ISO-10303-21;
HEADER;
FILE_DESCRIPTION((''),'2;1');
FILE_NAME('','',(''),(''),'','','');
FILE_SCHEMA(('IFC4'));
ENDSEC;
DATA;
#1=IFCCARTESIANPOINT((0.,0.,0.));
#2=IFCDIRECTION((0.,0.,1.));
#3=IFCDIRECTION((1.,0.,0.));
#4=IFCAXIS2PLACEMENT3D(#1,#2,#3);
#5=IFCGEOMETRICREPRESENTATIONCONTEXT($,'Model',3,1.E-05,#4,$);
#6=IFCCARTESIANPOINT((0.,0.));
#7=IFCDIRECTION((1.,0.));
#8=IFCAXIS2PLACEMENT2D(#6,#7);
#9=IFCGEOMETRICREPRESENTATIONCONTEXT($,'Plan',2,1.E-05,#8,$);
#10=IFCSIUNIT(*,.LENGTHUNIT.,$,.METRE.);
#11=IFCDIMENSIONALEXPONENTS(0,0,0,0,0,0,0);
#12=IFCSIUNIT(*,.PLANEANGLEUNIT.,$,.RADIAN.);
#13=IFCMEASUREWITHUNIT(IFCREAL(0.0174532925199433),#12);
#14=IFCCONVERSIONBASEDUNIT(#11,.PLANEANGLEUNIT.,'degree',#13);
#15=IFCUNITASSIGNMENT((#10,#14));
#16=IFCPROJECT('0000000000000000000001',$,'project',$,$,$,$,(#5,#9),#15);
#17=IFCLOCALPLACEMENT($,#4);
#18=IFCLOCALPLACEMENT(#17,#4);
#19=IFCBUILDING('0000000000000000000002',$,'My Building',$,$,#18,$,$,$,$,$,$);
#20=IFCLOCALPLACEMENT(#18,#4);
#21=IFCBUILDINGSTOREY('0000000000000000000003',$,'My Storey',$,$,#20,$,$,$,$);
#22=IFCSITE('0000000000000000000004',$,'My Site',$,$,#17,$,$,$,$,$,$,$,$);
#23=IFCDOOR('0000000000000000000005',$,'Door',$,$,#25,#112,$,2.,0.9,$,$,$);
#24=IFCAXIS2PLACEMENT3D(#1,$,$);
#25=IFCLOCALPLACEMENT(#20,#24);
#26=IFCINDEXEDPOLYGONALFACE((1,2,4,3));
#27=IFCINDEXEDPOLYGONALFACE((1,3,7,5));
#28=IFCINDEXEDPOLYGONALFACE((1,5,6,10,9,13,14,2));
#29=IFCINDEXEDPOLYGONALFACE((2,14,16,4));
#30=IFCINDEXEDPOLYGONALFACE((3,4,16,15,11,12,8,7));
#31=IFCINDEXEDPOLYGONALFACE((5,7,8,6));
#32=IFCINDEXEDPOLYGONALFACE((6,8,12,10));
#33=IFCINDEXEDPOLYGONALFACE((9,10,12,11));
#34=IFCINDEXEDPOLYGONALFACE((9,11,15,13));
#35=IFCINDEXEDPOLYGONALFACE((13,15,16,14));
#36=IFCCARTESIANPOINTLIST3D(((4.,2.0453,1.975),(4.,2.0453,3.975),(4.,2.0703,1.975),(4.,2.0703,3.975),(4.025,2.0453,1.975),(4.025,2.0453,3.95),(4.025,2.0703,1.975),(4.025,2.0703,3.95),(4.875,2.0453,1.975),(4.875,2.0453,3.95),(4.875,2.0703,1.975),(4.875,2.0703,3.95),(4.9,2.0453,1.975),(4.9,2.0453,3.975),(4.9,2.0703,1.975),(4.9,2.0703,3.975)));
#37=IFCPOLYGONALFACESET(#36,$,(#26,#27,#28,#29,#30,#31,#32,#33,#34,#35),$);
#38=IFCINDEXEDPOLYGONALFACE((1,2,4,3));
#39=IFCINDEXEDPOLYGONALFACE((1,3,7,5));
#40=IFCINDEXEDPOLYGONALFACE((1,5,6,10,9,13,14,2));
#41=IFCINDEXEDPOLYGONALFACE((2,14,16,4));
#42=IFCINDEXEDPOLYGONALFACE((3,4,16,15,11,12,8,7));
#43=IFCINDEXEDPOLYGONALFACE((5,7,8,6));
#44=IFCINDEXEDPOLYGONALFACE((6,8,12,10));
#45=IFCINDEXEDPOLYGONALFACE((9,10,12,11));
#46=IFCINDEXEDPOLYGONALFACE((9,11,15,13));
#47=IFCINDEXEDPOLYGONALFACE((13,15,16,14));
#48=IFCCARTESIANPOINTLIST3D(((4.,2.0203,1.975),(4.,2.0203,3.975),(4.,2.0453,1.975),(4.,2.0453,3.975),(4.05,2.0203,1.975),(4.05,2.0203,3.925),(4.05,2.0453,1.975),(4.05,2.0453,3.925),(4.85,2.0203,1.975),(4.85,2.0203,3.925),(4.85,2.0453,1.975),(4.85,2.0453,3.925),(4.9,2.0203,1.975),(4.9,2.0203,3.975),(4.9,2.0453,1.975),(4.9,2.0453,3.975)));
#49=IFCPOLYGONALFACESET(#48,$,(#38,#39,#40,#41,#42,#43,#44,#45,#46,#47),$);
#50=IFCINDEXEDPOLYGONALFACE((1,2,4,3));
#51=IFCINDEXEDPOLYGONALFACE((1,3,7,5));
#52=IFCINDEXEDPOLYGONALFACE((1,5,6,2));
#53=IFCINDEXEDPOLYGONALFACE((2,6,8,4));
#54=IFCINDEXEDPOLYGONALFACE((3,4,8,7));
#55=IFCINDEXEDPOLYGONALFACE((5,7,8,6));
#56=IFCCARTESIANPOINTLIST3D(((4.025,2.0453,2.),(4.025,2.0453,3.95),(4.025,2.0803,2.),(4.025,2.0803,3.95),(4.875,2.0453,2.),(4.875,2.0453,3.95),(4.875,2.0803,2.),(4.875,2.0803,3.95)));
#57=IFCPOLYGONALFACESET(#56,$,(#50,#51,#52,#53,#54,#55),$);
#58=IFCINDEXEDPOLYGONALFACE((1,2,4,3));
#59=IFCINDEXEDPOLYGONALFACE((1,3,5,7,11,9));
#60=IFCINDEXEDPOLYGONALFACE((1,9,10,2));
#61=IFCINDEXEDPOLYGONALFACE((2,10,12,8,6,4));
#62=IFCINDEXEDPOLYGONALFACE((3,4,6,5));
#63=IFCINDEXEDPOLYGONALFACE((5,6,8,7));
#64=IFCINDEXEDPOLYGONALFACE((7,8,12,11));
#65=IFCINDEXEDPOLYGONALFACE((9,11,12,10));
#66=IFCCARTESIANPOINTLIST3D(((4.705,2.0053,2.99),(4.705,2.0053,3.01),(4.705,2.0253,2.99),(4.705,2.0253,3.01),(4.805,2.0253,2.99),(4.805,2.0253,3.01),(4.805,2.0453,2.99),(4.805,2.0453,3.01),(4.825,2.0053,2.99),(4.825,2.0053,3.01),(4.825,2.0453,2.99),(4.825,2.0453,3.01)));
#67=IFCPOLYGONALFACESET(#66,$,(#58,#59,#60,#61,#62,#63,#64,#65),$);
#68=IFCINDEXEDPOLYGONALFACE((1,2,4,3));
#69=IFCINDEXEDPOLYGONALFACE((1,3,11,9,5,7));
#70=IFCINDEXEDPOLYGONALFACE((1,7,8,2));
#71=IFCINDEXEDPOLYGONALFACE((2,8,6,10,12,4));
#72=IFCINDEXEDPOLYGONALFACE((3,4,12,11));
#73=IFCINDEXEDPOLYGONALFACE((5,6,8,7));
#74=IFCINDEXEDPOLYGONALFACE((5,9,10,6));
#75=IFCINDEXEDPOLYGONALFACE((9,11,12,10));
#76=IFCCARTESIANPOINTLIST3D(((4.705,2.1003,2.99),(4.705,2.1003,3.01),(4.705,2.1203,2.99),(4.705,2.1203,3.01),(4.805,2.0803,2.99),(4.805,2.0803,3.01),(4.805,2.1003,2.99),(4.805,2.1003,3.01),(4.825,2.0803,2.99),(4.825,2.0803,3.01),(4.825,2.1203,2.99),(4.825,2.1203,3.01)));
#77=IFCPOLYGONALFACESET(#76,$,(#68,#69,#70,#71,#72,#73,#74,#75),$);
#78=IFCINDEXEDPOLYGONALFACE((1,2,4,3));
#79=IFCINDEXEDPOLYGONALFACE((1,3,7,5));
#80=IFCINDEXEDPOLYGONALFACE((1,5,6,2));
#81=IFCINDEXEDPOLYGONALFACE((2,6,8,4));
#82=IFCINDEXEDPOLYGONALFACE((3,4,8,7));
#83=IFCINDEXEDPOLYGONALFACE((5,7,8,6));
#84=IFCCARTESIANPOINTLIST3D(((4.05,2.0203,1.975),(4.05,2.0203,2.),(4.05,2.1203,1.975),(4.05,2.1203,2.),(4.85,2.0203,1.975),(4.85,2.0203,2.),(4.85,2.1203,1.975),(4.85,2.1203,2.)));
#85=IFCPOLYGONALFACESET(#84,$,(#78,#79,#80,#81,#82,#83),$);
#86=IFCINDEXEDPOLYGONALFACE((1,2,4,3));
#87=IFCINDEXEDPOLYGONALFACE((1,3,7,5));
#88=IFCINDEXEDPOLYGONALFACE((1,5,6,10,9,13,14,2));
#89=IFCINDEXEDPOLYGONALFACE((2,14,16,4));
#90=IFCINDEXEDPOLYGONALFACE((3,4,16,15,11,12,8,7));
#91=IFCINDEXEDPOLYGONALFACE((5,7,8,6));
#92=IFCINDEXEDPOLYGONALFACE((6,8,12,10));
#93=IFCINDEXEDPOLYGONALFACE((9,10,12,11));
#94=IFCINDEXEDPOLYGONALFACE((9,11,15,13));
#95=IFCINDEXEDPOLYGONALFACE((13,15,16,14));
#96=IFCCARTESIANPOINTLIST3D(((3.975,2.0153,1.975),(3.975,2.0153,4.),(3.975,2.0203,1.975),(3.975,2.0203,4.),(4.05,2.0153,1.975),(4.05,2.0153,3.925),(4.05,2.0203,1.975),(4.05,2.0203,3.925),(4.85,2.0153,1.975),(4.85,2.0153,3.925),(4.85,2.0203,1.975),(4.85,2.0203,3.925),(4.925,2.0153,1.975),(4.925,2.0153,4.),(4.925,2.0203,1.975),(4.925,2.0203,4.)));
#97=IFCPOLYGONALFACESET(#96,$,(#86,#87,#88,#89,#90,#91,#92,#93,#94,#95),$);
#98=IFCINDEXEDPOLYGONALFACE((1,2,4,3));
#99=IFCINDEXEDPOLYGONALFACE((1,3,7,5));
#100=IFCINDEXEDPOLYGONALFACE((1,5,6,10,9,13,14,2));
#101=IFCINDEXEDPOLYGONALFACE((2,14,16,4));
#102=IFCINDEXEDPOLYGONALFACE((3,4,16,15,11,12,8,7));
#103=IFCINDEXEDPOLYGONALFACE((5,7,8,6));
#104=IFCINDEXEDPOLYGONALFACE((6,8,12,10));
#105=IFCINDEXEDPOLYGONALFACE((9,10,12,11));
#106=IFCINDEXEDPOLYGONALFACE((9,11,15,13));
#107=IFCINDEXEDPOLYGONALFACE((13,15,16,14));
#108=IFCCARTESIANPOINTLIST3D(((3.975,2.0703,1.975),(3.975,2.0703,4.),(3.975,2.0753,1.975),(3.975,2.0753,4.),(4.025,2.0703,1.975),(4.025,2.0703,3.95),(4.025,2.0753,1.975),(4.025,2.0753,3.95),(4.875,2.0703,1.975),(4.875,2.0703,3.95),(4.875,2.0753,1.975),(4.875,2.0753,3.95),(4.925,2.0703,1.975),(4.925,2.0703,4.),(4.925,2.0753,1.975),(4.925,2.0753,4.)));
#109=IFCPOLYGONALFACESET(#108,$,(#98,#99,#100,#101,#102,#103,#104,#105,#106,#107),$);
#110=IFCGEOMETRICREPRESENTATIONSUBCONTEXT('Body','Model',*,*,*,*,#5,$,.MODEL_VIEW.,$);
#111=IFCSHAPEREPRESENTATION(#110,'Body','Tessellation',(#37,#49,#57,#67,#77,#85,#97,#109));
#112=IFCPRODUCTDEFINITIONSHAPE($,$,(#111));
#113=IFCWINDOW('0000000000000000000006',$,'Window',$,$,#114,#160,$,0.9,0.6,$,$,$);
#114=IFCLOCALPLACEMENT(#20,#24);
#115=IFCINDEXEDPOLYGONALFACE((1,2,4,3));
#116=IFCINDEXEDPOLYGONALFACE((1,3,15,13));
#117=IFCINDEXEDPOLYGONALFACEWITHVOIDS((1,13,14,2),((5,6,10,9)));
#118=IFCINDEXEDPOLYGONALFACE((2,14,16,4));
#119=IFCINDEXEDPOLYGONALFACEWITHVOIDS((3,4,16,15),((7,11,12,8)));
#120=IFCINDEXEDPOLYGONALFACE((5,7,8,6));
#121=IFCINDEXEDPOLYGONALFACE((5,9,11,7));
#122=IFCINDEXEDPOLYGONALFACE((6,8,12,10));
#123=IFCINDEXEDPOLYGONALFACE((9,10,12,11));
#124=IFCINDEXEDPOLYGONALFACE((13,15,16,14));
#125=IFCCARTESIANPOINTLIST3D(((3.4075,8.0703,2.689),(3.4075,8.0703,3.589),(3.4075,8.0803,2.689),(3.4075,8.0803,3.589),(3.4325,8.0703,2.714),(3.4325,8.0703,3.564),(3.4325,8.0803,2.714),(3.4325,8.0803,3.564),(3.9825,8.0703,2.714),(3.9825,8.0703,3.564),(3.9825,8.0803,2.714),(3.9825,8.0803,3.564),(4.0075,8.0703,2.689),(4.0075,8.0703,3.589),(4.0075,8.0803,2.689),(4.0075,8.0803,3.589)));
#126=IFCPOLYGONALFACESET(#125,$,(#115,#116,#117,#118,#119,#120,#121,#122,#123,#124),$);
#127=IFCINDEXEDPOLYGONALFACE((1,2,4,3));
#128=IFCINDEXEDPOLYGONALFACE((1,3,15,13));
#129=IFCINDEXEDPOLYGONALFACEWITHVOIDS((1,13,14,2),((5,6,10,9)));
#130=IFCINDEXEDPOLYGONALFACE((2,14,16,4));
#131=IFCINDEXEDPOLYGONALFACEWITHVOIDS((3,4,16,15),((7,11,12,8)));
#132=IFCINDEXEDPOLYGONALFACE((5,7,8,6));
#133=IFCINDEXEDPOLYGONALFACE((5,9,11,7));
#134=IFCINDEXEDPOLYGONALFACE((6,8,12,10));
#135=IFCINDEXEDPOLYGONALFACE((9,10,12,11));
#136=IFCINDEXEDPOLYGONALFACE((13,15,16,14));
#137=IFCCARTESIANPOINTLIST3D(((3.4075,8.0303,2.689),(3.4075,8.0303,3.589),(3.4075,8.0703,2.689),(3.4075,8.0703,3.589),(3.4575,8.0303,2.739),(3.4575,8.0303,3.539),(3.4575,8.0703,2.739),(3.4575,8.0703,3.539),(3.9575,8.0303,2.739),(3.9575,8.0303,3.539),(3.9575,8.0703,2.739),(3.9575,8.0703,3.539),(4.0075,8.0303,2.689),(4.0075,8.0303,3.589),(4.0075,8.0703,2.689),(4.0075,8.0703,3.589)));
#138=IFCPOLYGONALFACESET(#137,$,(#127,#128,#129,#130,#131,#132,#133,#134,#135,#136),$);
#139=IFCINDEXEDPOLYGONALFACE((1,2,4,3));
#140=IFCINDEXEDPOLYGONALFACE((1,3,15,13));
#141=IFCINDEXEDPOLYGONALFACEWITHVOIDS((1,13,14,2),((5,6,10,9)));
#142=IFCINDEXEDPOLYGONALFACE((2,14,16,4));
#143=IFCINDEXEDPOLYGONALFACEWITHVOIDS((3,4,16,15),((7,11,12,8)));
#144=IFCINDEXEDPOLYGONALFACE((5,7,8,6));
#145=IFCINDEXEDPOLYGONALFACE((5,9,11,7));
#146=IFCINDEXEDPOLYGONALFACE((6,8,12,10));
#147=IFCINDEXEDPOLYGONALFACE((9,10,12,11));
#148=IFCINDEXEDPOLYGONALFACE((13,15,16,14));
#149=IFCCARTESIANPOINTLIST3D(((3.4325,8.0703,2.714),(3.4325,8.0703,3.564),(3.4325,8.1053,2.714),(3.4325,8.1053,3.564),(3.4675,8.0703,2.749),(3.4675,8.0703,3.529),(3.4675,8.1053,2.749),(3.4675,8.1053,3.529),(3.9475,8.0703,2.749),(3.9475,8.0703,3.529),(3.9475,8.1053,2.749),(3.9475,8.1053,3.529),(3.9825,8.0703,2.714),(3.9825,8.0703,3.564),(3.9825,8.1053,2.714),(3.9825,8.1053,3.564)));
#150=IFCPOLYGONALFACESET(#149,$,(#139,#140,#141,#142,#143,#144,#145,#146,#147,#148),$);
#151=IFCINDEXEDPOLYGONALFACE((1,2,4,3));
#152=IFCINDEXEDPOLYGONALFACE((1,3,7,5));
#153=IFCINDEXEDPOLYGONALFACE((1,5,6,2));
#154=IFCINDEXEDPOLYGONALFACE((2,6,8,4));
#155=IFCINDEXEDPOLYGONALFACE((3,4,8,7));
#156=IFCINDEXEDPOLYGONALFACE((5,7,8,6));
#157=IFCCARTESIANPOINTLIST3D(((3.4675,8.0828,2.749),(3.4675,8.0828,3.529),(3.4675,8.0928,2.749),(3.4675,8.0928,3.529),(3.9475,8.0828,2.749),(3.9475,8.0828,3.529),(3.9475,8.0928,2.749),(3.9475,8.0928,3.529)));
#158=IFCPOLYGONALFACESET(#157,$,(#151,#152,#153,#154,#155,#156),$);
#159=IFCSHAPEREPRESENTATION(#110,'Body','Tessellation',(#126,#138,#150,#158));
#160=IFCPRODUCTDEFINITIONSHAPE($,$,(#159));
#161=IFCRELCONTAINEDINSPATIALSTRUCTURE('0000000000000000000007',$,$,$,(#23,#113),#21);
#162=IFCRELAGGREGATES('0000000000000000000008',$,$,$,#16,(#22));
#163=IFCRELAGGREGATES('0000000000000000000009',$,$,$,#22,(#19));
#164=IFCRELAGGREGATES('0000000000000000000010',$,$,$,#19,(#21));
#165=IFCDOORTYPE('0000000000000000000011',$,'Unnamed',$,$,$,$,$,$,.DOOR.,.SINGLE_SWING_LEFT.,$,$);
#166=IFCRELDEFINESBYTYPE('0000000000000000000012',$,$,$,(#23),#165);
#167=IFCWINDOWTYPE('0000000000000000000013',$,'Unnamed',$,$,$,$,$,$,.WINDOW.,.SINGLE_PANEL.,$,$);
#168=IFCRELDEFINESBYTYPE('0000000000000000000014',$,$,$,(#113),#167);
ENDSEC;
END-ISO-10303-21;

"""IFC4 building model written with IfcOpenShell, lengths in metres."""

from ifc_helpers import new_model, entity, si_unit, converted_unit, frame, origin_with_axes, origin_2d_with_axis, place, context, subcontext, project, spatial, line, indexed_curve, outline, extrude, shape, source, transform, mapped, type_object, type_shapes, element, save


model = new_model("IFC4")

# Units and contexts
model_context = context("Model", 3, precision=1e-05, world=origin_with_axes())
plan_context = context("Plan", 2, precision=1e-05, world=origin_2d_with_axis())
body_context_1 = subcontext(model_context, "Body", "Model", "MODEL_VIEW")
body_context_2 = subcontext(plan_context, "Body", "Plan", "PLAN_VIEW")
ifc_project = project(units=[si_unit("LENGTHUNIT", "METRE"), converted_unit("PLANEANGLEUNIT", "degree", entity("IfcReal", 0.0174532925199433), si_unit("PLANEANGLEUNIT", "RADIAN"), dimensions=[0, 0, 0, 0, 0, 0, 0])], contexts=[model_context, plan_context])

# Site, building, storey
site_placement = place(None, origin_with_axes())
site = spatial("IfcSite", under=ifc_project, at=site_placement, Name="My Site")
building_placement = place(site_placement, origin_with_axes())
building = spatial("IfcBuilding", under=site, at=building_placement, Name="My Building")
storey_placement = place(building_placement, origin_with_axes())
storey = spatial("IfcBuildingStorey", under=building, at=storey_placement, Name="My Storey")

# Door
door_type = type_object("IfcDoorType", Name="Unnamed", OperationType="SINGLE_SWING_LEFT", PredefinedType="DOOR")
shared_shape_1 = source(origin_with_axes(), body_context_1, "Body", "SolidModel", [
    extrude(outline(indexed_curve([(0.0, 0.0), (0.0, 2.0), (0.9, 2.0), (0.9, 0.0), (0.875, 0.0), (0.875, 1.975), (0.025, 1.975), (0.025, 0.0)], segments=[line(1, 2, 3, 4, 5, 6, 7, 8, 1)])), frame((0.0, 0.025, 0.0), z_axis=(0.0, -1.0, 0.0), x_axis=(1.0, 0.0, 0.0)), (0.0, 0.0, -1.0), 0.025),
    extrude(outline(indexed_curve([(0.0, 0.0), (0.0, 2.0), (0.9, 2.0), (0.9, 0.0), (0.85, 0.0), (0.85, 1.95), (0.05, 1.95), (0.05, 0.0)], segments=[line(1, 2, 3, 4, 5, 6, 7, 8, 1)])), frame((0.0, 0.0, 0.0), z_axis=(0.0, -1.0, 0.0), x_axis=(1.0, 0.0, 0.0)), (0.0, 0.0, -1.0), 0.025),
    extrude(outline(indexed_curve([(0.0, 0.0), (0.85, 0.0), (0.85, 0.035), (0.0, 0.035)], segments=[line(1, 2, 3, 4, 1)])), frame((0.025, 0.025, 0.025), z_axis=(0.0, 0.0, 1.0), x_axis=(1.0, 0.0, 0.0)), (0.0, 0.0, 1.0), 1.95),
    extrude(outline(indexed_curve([(0.0, 0.0), (0.0, -0.04), (-0.12, -0.04), (-0.12, -0.02), (-0.02, -0.02), (-0.02, 0.0)], segments=[line(1, 2, 3, 4, 5, 6, 1)])), frame((0.825, 0.025, 1.015), z_axis=(0.0, 0.0, 1.0), x_axis=(1.0, 0.0, 0.0)), (0.0, 0.0, 1.0), 0.02),
    extrude(outline(indexed_curve([(0.0, 0.0), (0.0, 0.04), (-0.12, 0.04), (-0.12, 0.02), (-0.02, 0.02), (-0.02, 0.0)], segments=[line(1, 2, 3, 4, 5, 6, 1)])), frame((0.825, 0.06, 1.015), z_axis=(0.0, 0.0, 1.0), x_axis=(1.0, 0.0, 0.0)), (0.0, 0.0, 1.0), 0.02),
    extrude(outline(indexed_curve([(0.0, 0.0), (0.8, 0.0), (0.8, 0.1), (0.0, 0.1)], segments=[line(1, 2, 3, 4, 1)])), frame((0.05, 0.0, 0.0), z_axis=(0.0, 0.0, 1.0), x_axis=(1.0, 0.0, 0.0)), (0.0, 0.0, 1.0), 0.025),
    extrude(outline(indexed_curve([(0.0, 0.0), (0.0, 2.025), (0.95, 2.025), (0.95, 0.0), (0.875, 0.0), (0.875, 1.95), (0.075, 1.95), (0.075, 0.0)], segments=[line(1, 2, 3, 4, 5, 6, 7, 8, 1)])), frame((-0.025, -0.005, 0.0), z_axis=(0.0, -1.0, 0.0), x_axis=(1.0, 0.0, 0.0)), (0.0, 0.0, -1.0), 0.005),
    extrude(outline(indexed_curve([(0.0, 0.0), (0.0, 2.025), (0.95, 2.025), (0.95, 0.0), (0.9, 0.0), (0.9, 1.975), (0.05, 1.975), (0.05, 0.0)], segments=[line(1, 2, 3, 4, 5, 6, 7, 8, 1)])), frame((-0.025, 0.05, 0.0), z_axis=(0.0, -1.0, 0.0), x_axis=(1.0, 0.0, 0.0)), (0.0, 0.0, -1.0), 0.005),
])
shared_shape_2 = source(origin_with_axes(), body_context_2, "Body", "Curve2D", [
    entity("IfcIndexedPolyCurve", entity("IfcCartesianPointList2D", [[0.0, 0.0], [0.0, 0.05], [0.025, 0.05], [0.025, 0.025], [0.05, 0.025], [0.05, 0.0]]), [entity("IfcLineIndex", [1, 2, 3, 4, 5, 6, 1])]),
    entity("IfcIndexedPolyCurve", entity("IfcCartesianPointList2D", [[0.9, 0.0], [0.9, 0.05], [0.875, 0.05], [0.875, 0.025], [0.85, 0.025], [0.85, 0.0]]), [entity("IfcLineIndex", [1, 2, 3, 4, 5, 6, 1])]),
    entity("IfcTrimmedCurve", entity("IfcEllipse", entity("IfcAxis2Placement2D", entity("IfcCartesianPoint", [0.06, 0.05]), entity("IfcDirection", [1.0, 0.0])), 0.815, 0.85), [entity("IfcCartesianPoint", [0.875, 0.05])], [entity("IfcCartesianPoint", [0.06, 0.9])], True, "CARTESIAN"),
    entity("IfcIndexedPolyCurve", entity("IfcCartesianPointList2D", [[0.025, 0.05], [0.06, 0.05], [0.06, 0.9], [0.025, 0.9]]), [entity("IfcLineIndex", [1, 2, 3, 4, 1])]),
])
type_shapes(door_type, [shared_shape_1, shared_shape_2])
door_placement = place(storey_placement, frame((4.0, 2.0203, 1.975), z_axis=(0.0, 0.0, 1.0), x_axis=(1.0, 0.0, 0.0)))
element("IfcDoor", 1, at=door_placement, inside=storey, type_object=door_type, Name="Door", OverallHeight=2.0, OverallWidth=0.9, shapes=[
    shape(body_context_1, "Body", "MappedRepresentation", [mapped(shared_shape_1, transform((0.0, 0.0, 0.0), x_axis=(1.0, 0.0, 0.0), y_axis=(0.0, 1.0, 0.0), z_axis=(0.0, 0.0, 1.0), scale=1.0))]),
    shape(body_context_2, "Body", "MappedRepresentation", [mapped(shared_shape_2, transform((0.0, 0.0, 0.0), x_axis=(1.0, 0.0, 0.0), y_axis=(0.0, 1.0, 0.0), z_axis=(0.0, 0.0, 1.0), scale=1.0))]),
])

# Window
window_type = type_object("IfcWindowType", Name="Unnamed", PartitioningType="SINGLE_PANEL", PredefinedType="WINDOW")
shared_shape_3 = source(origin_with_axes(), body_context_1, "Body", "SolidModel", [
    extrude(outline(indexed_curve([(0.0, 0.0), (0.6, 0.0), (0.6, 0.9), (0.0, 0.9)], segments=[line(1, 2, 3, 4, 1)]), holes=[indexed_curve([(0.025, 0.025), (0.575, 0.025), (0.575, 0.875), (0.025, 0.875)], segments=[line(1, 2, 3, 4, 1)])]), frame((0.0, 0.09, 0.0), z_axis=(0.0, -1.0, 0.0), x_axis=(1.0, 0.0, 0.0)), (0.0, 0.0, -1.0), 0.01),
    extrude(outline(indexed_curve([(0.0, 0.0), (0.6, 0.0), (0.6, 0.9), (0.0, 0.9)], segments=[line(1, 2, 3, 4, 1)]), holes=[indexed_curve([(0.05, 0.05), (0.55, 0.05), (0.55, 0.85), (0.05, 0.85)], segments=[line(1, 2, 3, 4, 1)])]), frame((0.0, 0.05, 0.0), z_axis=(0.0, -1.0, 0.0), x_axis=(1.0, 0.0, 0.0)), (0.0, 0.0, -1.0), 0.04),
    extrude(outline(indexed_curve([(0.0, 0.0), (0.55, 0.0), (0.55, 0.85), (0.0, 0.85)], segments=[line(1, 2, 3, 4, 1)]), holes=[indexed_curve([(0.035, 0.035), (0.515, 0.035), (0.515, 0.815), (0.035, 0.815)], segments=[line(1, 2, 3, 4, 1)])]), frame((0.025, 0.09, 0.025), z_axis=(0.0, -1.0, 0.0), x_axis=(1.0, 0.0, 0.0)), (0.0, 0.0, -1.0), 0.035),
    extrude(outline(indexed_curve([(0.035, 0.035), (0.515, 0.035), (0.515, 0.815), (0.035, 0.815)], segments=[line(1, 2, 3, 4, 1)])), frame((0.025, 0.1025, 0.025), z_axis=(0.0, -1.0, 0.0), x_axis=(1.0, 0.0, 0.0)), (0.0, 0.0, -1.0), 0.01),
])
shared_shape_4 = source(origin_with_axes(), body_context_2, "Body", "Curve2D", [
    entity("IfcIndexedPolyCurve", entity("IfcCartesianPointList2D", [[0.05, 0.05], [0.55, 0.05]])),
    entity("IfcIndexedPolyCurve", entity("IfcCartesianPointList2D", [[0.0, 0.1], [0.025, 0.1], [0.025, 0.09], [0.05, 0.09], [0.05, 0.05], [0.0, 0.05]]), [entity("IfcLineIndex", [1, 2, 3, 4, 5, 6, 1])]),
    entity("IfcIndexedPolyCurve", entity("IfcCartesianPointList2D", [[0.6, 0.1], [0.575, 0.1], [0.575, 0.09], [0.55, 0.09], [0.55, 0.05], [0.6, 0.05]]), [entity("IfcLineIndex", [1, 2, 3, 4, 5, 6, 1])]),
    entity("IfcIndexedPolyCurve", entity("IfcCartesianPointList2D", [[0.025, 0.09], [0.06, 0.09], [0.06, 0.125], [0.025, 0.125]]), [entity("IfcLineIndex", [1, 2, 3, 4, 1])]),
    entity("IfcIndexedPolyCurve", entity("IfcCartesianPointList2D", [[0.575, 0.09], [0.54, 0.09], [0.54, 0.125], [0.575, 0.125]]), [entity("IfcLineIndex", [1, 2, 3, 4, 1])]),
    entity("IfcIndexedPolyCurve", entity("IfcCartesianPointList2D", [[0.06, 0.09], [0.54, 0.09]])),
    entity("IfcIndexedPolyCurve", entity("IfcCartesianPointList2D", [[0.06, 0.125], [0.54, 0.125]])),
    entity("IfcIndexedPolyCurve", entity("IfcCartesianPointList2D", [[0.06, 0.1075], [0.54, 0.1075]])),
])
type_shapes(window_type, [shared_shape_3, shared_shape_4])
window_placement = place(storey_placement, frame((3.4075, 7.9803, 2.689), z_axis=(0.0, 0.0, 1.0), x_axis=(1.0, 0.0, 0.0)))
element("IfcWindow", 2, at=window_placement, inside=storey, type_object=window_type, Name="Window", OverallHeight=0.9, OverallWidth=0.6, shapes=[
    shape(body_context_1, "Body", "MappedRepresentation", [mapped(shared_shape_3, transform((0.0, 0.0, 0.0), x_axis=(1.0, 0.0, 0.0), y_axis=(0.0, 1.0, 0.0), z_axis=(0.0, 0.0, 1.0), scale=1.0))]),
    shape(body_context_2, "Body", "MappedRepresentation", [mapped(shared_shape_4, transform((0.0, 0.0, 0.0), x_axis=(1.0, 0.0, 0.0), y_axis=(0.0, 1.0, 0.0), z_axis=(0.0, 0.0, 1.0), scale=1.0))]),
])

save(model, "model.ifc")
